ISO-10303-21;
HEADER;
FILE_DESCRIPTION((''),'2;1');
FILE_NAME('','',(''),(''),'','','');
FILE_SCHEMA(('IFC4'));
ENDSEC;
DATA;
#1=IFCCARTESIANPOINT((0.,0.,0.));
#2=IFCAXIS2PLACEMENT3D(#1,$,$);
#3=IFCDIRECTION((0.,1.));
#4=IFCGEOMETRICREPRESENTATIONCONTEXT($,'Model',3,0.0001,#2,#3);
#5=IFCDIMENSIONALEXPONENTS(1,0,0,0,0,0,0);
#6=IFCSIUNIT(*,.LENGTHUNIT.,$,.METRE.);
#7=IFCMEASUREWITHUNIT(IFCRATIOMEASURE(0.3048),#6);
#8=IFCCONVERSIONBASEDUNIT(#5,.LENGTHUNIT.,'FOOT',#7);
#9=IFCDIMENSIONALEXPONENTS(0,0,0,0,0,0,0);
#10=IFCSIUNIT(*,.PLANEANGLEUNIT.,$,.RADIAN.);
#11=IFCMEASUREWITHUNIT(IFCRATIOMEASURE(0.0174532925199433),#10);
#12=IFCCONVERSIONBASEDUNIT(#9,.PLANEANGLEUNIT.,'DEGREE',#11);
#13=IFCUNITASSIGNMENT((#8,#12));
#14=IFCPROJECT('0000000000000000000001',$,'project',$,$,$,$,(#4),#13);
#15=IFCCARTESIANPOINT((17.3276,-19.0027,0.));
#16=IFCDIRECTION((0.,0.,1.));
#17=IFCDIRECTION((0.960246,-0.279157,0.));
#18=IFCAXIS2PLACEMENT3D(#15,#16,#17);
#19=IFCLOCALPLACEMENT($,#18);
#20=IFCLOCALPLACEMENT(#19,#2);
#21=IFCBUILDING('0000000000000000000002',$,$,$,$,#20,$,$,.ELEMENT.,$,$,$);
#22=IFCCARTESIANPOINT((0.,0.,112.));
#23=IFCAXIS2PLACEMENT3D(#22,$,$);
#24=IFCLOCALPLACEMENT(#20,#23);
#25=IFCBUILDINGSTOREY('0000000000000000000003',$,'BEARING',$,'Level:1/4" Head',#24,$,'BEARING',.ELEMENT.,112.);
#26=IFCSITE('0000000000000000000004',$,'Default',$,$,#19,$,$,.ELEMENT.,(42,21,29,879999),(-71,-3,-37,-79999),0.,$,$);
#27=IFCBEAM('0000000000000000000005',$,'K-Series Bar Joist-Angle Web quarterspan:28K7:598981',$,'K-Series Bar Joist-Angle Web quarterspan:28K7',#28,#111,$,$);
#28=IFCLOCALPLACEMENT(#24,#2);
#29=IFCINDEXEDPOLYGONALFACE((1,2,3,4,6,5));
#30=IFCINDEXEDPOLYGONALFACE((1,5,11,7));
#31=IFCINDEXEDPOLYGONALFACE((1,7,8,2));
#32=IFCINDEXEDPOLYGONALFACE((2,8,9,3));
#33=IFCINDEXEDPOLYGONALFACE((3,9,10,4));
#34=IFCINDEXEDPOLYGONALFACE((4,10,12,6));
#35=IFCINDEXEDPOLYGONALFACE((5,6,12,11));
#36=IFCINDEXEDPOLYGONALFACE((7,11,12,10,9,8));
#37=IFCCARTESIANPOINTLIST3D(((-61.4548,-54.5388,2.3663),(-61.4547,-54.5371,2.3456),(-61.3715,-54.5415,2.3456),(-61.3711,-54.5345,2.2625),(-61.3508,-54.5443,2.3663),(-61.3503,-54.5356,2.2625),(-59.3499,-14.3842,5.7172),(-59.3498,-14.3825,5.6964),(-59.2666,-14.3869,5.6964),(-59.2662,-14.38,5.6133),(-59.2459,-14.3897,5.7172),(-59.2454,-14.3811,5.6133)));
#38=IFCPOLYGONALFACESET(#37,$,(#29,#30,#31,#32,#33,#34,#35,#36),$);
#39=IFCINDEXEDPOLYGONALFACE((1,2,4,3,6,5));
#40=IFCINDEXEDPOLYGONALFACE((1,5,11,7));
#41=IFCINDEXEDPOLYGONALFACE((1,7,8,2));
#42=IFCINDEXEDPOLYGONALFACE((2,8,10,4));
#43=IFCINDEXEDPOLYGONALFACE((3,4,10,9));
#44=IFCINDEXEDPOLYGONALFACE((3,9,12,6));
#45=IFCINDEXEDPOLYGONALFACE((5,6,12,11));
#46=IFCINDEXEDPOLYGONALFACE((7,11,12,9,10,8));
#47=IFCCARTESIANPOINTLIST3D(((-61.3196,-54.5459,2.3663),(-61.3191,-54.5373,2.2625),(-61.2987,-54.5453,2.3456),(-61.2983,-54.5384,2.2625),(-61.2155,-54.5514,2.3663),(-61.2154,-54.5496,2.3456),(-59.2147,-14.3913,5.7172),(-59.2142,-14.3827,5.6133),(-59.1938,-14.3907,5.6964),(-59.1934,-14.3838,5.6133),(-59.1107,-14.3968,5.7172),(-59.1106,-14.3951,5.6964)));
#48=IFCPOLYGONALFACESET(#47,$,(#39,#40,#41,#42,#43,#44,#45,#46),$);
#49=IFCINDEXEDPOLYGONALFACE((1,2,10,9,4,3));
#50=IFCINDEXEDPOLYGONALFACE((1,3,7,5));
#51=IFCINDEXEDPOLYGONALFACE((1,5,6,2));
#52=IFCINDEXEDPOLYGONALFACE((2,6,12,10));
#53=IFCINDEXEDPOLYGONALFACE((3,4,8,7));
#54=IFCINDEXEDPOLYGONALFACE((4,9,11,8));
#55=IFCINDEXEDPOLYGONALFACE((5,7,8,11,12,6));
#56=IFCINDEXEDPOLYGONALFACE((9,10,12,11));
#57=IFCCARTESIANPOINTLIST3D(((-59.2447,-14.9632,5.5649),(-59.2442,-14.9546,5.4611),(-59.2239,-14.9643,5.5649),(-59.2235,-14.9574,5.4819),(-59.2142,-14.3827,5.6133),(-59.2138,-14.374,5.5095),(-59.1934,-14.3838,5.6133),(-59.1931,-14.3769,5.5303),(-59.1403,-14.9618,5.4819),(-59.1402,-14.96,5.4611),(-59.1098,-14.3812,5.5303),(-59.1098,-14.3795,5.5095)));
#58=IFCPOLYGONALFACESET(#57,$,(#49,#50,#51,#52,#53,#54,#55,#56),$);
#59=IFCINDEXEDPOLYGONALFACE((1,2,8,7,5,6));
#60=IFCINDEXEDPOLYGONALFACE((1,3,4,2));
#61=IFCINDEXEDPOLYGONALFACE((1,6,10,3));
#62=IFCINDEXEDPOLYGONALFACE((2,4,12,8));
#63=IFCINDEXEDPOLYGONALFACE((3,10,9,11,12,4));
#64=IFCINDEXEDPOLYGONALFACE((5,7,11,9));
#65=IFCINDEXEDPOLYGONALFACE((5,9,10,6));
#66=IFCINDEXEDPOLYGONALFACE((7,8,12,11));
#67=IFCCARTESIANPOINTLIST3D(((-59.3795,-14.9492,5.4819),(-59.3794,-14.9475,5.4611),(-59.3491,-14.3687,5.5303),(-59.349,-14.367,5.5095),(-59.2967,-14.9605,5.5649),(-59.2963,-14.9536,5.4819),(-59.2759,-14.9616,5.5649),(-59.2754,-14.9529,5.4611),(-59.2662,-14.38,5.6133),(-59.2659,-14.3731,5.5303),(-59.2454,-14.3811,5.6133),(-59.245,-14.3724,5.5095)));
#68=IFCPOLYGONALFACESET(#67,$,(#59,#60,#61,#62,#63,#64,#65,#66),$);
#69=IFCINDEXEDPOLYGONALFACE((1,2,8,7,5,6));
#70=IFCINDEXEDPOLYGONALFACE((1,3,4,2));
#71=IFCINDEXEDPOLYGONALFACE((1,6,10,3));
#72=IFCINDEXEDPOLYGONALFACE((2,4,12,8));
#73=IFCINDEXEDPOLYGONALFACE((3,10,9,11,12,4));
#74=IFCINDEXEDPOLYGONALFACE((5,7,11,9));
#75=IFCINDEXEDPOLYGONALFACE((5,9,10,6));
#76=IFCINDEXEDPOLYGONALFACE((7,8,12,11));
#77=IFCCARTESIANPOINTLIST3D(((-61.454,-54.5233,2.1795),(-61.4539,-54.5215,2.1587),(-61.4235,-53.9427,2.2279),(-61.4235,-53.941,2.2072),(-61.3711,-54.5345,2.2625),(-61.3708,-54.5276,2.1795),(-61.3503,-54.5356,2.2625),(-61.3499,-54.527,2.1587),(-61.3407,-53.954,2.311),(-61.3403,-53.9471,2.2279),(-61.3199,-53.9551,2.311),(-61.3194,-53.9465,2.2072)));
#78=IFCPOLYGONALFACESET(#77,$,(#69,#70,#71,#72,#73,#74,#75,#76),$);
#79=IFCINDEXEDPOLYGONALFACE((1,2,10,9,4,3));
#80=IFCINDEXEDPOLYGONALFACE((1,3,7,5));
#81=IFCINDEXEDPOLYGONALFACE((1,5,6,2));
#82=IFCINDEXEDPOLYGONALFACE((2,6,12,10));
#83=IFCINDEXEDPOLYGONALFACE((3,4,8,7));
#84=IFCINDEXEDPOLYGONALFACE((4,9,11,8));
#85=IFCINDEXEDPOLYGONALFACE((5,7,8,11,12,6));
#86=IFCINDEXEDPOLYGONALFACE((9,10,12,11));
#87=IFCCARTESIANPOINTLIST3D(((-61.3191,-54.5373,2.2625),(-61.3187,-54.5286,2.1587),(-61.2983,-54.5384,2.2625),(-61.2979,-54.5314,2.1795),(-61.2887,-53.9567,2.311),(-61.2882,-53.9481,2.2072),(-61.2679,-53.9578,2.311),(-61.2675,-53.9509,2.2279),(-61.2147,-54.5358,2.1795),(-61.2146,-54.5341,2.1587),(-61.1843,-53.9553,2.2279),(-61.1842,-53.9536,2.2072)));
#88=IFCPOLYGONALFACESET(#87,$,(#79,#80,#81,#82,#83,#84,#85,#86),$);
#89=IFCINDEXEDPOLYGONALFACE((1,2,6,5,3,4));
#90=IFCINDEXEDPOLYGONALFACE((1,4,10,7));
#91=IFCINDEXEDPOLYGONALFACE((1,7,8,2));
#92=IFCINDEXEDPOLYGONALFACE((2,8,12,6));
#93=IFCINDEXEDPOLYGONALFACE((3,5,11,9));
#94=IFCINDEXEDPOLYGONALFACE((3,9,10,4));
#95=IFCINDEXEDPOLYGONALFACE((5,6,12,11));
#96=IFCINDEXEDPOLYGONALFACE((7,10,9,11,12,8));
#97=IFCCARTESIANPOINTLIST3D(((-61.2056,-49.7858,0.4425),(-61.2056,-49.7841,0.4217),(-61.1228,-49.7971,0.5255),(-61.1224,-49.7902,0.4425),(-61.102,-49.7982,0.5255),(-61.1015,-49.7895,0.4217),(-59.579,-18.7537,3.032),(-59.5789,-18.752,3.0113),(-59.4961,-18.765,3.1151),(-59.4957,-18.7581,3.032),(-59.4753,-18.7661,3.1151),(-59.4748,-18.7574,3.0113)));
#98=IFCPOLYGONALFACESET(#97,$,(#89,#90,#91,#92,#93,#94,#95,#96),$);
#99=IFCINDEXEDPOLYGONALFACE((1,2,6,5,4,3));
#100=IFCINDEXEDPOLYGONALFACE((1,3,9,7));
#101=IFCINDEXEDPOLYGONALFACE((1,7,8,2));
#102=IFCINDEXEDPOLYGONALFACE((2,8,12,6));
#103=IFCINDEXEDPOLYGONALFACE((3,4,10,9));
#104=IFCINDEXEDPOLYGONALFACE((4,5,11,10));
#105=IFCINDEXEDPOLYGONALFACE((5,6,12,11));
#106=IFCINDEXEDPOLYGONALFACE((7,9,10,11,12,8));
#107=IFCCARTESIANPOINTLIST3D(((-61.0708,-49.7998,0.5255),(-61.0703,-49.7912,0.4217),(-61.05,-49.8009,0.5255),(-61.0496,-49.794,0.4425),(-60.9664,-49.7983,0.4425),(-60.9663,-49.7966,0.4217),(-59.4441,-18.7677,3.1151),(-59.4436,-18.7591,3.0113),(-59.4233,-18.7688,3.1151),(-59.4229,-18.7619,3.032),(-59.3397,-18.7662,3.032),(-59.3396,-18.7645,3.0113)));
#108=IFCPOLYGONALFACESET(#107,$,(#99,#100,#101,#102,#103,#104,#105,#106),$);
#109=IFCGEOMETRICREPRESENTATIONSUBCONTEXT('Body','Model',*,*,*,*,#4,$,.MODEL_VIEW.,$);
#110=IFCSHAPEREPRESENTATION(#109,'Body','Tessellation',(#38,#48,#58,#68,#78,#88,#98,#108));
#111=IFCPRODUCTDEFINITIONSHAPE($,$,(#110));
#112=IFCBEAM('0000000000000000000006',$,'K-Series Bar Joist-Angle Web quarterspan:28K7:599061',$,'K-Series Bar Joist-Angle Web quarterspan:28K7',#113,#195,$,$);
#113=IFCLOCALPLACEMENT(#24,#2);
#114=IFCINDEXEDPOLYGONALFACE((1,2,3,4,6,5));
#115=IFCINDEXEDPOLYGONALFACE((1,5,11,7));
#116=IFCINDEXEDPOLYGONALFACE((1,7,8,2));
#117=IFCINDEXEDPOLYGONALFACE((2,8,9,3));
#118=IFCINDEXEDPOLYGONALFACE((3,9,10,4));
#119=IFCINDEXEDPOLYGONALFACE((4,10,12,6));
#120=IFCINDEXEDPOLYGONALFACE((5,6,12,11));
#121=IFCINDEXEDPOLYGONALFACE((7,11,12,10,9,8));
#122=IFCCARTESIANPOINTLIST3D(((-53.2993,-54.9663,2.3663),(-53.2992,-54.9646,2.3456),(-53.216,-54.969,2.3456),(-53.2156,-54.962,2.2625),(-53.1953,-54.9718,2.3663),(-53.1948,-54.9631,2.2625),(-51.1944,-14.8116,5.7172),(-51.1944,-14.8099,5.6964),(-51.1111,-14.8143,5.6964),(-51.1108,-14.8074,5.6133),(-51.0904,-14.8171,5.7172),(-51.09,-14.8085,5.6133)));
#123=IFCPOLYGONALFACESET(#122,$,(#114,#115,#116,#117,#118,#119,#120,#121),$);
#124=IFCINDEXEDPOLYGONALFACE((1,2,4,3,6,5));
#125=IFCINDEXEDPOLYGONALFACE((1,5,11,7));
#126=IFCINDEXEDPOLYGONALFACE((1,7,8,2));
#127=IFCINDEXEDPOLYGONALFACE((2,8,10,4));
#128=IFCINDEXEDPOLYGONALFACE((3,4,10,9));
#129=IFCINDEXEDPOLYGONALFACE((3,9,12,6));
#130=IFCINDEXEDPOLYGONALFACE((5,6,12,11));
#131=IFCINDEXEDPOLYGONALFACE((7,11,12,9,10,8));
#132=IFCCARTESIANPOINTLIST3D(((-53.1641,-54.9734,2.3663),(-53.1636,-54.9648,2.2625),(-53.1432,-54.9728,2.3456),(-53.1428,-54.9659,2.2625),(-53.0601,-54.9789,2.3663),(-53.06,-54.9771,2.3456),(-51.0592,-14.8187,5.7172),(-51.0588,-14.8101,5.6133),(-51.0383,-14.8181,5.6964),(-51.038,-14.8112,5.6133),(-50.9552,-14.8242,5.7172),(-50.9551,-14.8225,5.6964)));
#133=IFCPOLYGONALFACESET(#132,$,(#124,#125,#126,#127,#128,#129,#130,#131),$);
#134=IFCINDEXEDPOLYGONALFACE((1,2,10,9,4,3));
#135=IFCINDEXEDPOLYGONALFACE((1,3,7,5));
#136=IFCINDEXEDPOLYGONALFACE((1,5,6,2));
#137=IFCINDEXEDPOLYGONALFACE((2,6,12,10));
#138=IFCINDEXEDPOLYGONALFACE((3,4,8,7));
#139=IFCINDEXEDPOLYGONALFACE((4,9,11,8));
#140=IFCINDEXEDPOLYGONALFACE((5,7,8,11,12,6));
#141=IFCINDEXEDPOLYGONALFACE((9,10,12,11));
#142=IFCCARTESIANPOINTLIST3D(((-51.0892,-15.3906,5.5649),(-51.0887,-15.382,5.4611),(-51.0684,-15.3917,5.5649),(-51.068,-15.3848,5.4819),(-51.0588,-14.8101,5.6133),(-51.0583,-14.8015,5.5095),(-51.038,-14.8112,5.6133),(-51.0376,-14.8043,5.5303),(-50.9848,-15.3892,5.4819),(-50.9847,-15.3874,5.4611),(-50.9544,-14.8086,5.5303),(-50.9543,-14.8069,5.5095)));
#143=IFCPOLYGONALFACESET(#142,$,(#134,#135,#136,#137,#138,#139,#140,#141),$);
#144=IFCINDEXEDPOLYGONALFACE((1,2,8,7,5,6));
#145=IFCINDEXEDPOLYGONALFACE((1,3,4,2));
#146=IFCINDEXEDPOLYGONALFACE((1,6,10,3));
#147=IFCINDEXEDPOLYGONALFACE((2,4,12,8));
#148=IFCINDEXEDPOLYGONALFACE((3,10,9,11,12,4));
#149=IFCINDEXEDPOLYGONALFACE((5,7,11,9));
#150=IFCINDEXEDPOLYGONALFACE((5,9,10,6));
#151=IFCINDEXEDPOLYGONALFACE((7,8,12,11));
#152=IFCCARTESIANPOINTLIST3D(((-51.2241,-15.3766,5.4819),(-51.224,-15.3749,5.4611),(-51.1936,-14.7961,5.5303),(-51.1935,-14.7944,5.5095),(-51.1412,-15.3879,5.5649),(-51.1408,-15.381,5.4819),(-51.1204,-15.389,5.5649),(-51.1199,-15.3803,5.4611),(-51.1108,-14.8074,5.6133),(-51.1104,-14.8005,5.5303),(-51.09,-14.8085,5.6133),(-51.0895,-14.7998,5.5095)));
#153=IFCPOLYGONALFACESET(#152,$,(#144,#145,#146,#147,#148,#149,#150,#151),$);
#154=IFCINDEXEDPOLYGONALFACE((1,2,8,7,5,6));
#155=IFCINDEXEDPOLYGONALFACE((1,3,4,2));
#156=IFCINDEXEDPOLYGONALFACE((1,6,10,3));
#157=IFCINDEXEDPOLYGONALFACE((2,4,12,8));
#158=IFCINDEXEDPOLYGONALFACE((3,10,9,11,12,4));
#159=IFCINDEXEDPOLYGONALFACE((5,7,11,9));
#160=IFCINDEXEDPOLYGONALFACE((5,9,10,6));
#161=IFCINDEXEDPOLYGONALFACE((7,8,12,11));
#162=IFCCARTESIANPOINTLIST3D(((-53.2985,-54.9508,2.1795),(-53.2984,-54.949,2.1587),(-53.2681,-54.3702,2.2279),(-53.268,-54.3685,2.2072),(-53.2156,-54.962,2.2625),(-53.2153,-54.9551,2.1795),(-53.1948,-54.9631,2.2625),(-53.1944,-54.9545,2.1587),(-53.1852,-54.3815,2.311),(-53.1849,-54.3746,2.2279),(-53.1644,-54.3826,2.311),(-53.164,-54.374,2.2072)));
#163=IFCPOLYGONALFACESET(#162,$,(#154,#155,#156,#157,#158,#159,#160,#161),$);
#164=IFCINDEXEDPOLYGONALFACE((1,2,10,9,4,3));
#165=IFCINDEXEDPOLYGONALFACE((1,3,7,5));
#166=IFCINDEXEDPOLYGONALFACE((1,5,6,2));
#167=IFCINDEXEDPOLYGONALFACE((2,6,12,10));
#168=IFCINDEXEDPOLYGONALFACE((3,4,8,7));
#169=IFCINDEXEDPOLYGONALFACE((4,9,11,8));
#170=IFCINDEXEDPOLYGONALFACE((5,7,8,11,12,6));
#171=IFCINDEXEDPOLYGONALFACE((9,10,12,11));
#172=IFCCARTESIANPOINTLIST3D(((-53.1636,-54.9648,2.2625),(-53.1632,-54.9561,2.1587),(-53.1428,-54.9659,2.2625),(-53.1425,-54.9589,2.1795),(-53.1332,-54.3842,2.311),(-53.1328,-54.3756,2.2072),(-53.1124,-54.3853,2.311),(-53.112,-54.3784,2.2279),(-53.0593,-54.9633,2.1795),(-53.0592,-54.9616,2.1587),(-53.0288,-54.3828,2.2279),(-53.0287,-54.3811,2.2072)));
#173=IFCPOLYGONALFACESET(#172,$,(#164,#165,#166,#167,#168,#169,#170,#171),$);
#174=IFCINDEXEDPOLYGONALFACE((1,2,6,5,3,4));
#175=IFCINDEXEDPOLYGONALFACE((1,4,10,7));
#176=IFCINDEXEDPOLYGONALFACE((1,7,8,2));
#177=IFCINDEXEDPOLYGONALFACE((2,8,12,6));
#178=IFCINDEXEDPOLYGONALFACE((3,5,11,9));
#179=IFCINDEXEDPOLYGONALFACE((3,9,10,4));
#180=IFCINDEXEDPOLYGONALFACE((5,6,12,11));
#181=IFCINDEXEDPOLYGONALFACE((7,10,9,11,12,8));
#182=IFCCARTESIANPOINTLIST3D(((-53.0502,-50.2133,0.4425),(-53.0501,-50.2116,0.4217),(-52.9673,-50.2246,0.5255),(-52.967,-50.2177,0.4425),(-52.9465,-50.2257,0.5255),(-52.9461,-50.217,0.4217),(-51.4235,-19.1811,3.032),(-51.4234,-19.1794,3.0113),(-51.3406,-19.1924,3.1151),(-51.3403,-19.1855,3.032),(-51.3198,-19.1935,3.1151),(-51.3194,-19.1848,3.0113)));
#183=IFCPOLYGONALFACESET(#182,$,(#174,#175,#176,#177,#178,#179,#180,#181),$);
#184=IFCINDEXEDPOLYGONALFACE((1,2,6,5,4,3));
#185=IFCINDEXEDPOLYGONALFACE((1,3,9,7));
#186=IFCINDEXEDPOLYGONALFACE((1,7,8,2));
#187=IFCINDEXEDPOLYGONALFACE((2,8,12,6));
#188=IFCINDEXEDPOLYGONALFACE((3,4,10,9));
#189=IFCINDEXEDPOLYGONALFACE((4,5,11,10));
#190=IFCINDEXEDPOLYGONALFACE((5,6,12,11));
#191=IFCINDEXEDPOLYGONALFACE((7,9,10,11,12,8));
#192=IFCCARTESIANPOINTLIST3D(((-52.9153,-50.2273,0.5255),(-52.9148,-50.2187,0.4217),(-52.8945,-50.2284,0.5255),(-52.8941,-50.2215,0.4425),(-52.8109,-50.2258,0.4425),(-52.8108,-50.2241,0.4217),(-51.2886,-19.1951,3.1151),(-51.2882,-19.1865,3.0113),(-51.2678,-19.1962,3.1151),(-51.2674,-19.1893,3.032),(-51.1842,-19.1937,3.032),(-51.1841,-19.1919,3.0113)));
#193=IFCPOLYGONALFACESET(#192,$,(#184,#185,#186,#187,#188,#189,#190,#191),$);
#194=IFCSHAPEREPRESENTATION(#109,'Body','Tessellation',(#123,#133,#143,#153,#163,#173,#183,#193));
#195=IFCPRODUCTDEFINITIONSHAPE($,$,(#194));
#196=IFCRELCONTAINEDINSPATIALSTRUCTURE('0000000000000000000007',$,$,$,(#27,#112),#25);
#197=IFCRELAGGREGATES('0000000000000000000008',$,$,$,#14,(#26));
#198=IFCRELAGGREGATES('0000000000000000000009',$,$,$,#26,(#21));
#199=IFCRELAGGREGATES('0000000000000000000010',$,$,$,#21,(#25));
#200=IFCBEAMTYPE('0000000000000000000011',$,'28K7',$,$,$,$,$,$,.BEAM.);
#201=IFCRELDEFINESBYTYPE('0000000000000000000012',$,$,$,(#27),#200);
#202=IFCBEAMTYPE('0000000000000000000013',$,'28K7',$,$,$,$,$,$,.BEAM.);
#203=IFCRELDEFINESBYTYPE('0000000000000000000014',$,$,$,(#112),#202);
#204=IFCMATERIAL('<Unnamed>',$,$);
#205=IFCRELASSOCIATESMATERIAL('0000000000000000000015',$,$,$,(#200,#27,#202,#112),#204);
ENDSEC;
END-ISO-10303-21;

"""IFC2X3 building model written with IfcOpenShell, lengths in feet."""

from ifc_helpers import new_model, entity, si_unit, converted_unit, direction, frame, origin, place, context, subcontext, project, spatial, polyline, outline, extrude, source, transform, mapped, material, type_object, type_shapes, element, save


model = new_model("IFC2X3")

# Units and contexts
model_context = context("Model", 3, precision=0.0001, world=origin(), true_north=direction((0.0, 1.0)))
body_context = subcontext(model_context, "Body", "Model", "MODEL_VIEW")
ifc_project = project(units=[converted_unit("LENGTHUNIT", "FOOT", entity("IfcRatioMeasure", 0.3048), si_unit("LENGTHUNIT", "METRE"), dimensions=[1, 0, 0, 0, 0, 0, 0]), converted_unit("PLANEANGLEUNIT", "DEGREE", entity("IfcRatioMeasure", 0.0174532925199433), si_unit("PLANEANGLEUNIT", "RADIAN"), dimensions=[0, 0, 0, 0, 0, 0, 0])], contexts=[model_context])

# Site, building, storey
site_placement = place(None, frame((17.3276, -19.0027, 0.0), z_axis=(0.0, 0.0, 1.0), x_axis=(0.960246, -0.279157, 0.0)))
site = spatial("IfcSite", under=ifc_project, at=site_placement, Name="Default", CompositionType="ELEMENT", RefLatitude=(42, 21, 29, 879999), RefLongitude=(-71, -3, -37, -79999), RefElevation=0.0)
building_placement = place(site_placement, origin())
building = spatial("IfcBuilding", under=site, at=building_placement, CompositionType="ELEMENT")
storey_placement = place(building_placement, frame((0.0, 0.0, 112.0)))
storey = spatial("IfcBuildingStorey", under=building, at=storey_placement, Name="BEARING", ObjectType="Level:1/4\" Head", LongName="BEARING", CompositionType="ELEMENT", Elevation=112.0)

# Shared definitions
ifc_material_1 = material(Name="<Unnamed>")

# Beams
beam_type_1 = type_object("IfcBeamType", Name="28K7", PredefinedType="BEAM", material=ifc_material_1)
shared_shape_1 = source(origin(), body_context, "Body", "SweptSolid", [
    extrude(outline(polyline([(-0.0417, -0.0625), (-0.0208, -0.0625), (-0.0208, 0.0208), (0.0625, 0.0208), (0.0625, 0.0417), (-0.0417, 0.0417), (-0.0417, -0.0625)])), frame((-20.1745, -0.0573, 1.125), z_axis=(1.0, 0.0, 0.0), x_axis=(0.0, 0.0, -1.0)), (0.0, 0.0, 1.0), 40.3491),
    extrude(outline(polyline([(-0.0417, -0.0417), (0.0625, -0.0417), (0.0625, -0.0208), (-0.0208, -0.0208), (-0.0208, 0.0625), (-0.0417, 0.0625), (-0.0417, -0.0417)])), frame((-20.1745, 0.0573, 1.125), z_axis=(1.0, 0.0, 0.0), x_axis=(0.0, 0.0, -1.0)), (0.0, 0.0, 1.0), 40.3491),
    extrude(outline(polyline([(-0.0625, -0.0417), (0.0417, -0.0417), (0.0417, 0.0625), (0.0208, 0.0625), (0.0208, -0.0208), (-0.0625, -0.0208), (-0.0625, -0.0417)])), frame((-20.1745, 0.0573, 1.0), z_axis=(1.0, 0.0, 0.0), x_axis=(0.0, 0.0, -1.0)), (0.0, 0.0, 1.0), 0.5833),
    extrude(outline(polyline([(0.0208, -0.0625), (0.0417, -0.0625), (0.0417, 0.0417), (-0.0625, 0.0417), (-0.0625, 0.0208), (0.0208, 0.0208), (0.0208, -0.0625)])), frame((-20.1745, -0.0573, 1.0), z_axis=(1.0, 0.0, 0.0), x_axis=(0.0, 0.0, -1.0)), (0.0, 0.0, 1.0), 0.5833),
    extrude(outline(polyline([(0.0208, -0.0625), (0.0417, -0.0625), (0.0417, 0.0417), (-0.0625, 0.0417), (-0.0625, 0.0208), (0.0208, 0.0208), (0.0208, -0.0625)])), frame((19.5912, -0.0573, 1.0), z_axis=(1.0, 0.0, 0.0), x_axis=(0.0, 0.0, -1.0)), (0.0, 0.0, 1.0), 0.5833),
    extrude(outline(polyline([(-0.0625, -0.0417), (0.0417, -0.0417), (0.0417, 0.0625), (0.0208, 0.0625), (0.0208, -0.0208), (-0.0625, -0.0208), (-0.0625, -0.0417)])), frame((19.5912, 0.0573, 1.0), z_axis=(1.0, 0.0, 0.0), x_axis=(0.0, 0.0, -1.0)), (0.0, 0.0, 1.0), 0.5833),
    extrude(outline(polyline([(0.0208, -0.0625), (0.0417, -0.0625), (0.0417, 0.0417), (-0.0625, 0.0417), (-0.0625, 0.0208), (0.0208, 0.0208), (0.0208, -0.0625)])), frame((-15.5912, -0.0573, -1.125), z_axis=(1.0, 0.0, 0.0), x_axis=(0.0, 0.0, -1.0)), (0.0, 0.0, 1.0), 31.1824),
    extrude(outline(polyline([(-0.0625, -0.0417), (0.0417, -0.0417), (0.0417, 0.0625), (0.0208, 0.0625), (0.0208, -0.0208), (-0.0625, -0.0208), (-0.0625, -0.0417)])), frame((-15.5912, 0.0573, -1.125), z_axis=(1.0, 0.0, 0.0), x_axis=(0.0, 0.0, -1.0)), (0.0, 0.0, 1.0), 31.1824),
])
type_shapes(beam_type_1, [shared_shape_1])
beam_1_placement = place(storey_placement, frame((-60.2777, -34.371, 2.8791), z_axis=(-0.004347, -0.082932, 0.996546), x_axis=(-0.052167, -0.995179, -0.083046)))
element("IfcBeam", 1, at=beam_1_placement, inside=storey, type_object=beam_type_1, material=ifc_material_1, Name="K-Series Bar Joist-Angle Web quarterspan:28K7:598981", ObjectType="K-Series Bar Joist-Angle Web quarterspan:28K7", context=body_context, shape_type="MappedRepresentation", body=[
    mapped(shared_shape_1, transform((0.0, 0.0, 0.0), scale=1.0)),
])
beam_type_2 = type_object("IfcBeamType", Name="28K7", PredefinedType="BEAM", material=ifc_material_1)
shared_shape_2 = source(origin(), body_context, "Body", "SweptSolid", [
    extrude(outline(polyline([(-0.0417, -0.0625), (-0.0208, -0.0625), (-0.0208, 0.0208), (0.0625, 0.0208), (0.0625, 0.0417), (-0.0417, 0.0417), (-0.0417, -0.0625)])), frame((-20.1746, -0.0573, 1.125), z_axis=(1.0, 0.0, 0.0), x_axis=(0.0, 0.0, -1.0)), (0.0, 0.0, 1.0), 40.3492),
    extrude(outline(polyline([(-0.0417, -0.0417), (0.0625, -0.0417), (0.0625, -0.0208), (-0.0208, -0.0208), (-0.0208, 0.0625), (-0.0417, 0.0625), (-0.0417, -0.0417)])), frame((-20.1746, 0.0573, 1.125), z_axis=(1.0, 0.0, 0.0), x_axis=(0.0, 0.0, -1.0)), (0.0, 0.0, 1.0), 40.3492),
    extrude(outline(polyline([(-0.0625, -0.0417), (0.0417, -0.0417), (0.0417, 0.0625), (0.0208, 0.0625), (0.0208, -0.0208), (-0.0625, -0.0208), (-0.0625, -0.0417)])), frame((-20.1746, 0.0573, 1.0), z_axis=(1.0, 0.0, 0.0), x_axis=(0.0, 0.0, -1.0)), (0.0, 0.0, 1.0), 0.5833),
    extrude(outline(polyline([(0.0208, -0.0625), (0.0417, -0.0625), (0.0417, 0.0417), (-0.0625, 0.0417), (-0.0625, 0.0208), (0.0208, 0.0208), (0.0208, -0.0625)])), frame((-20.1746, -0.0573, 1.0), z_axis=(1.0, 0.0, 0.0), x_axis=(0.0, 0.0, -1.0)), (0.0, 0.0, 1.0), 0.5833),
    extrude(outline(polyline([(0.0208, -0.0625), (0.0417, -0.0625), (0.0417, 0.0417), (-0.0625, 0.0417), (-0.0625, 0.0208), (0.0208, 0.0208), (0.0208, -0.0625)])), frame((19.5913, -0.0573, 1.0), z_axis=(1.0, 0.0, 0.0), x_axis=(0.0, 0.0, -1.0)), (0.0, 0.0, 1.0), 0.5833),
    extrude(outline(polyline([(-0.0625, -0.0417), (0.0417, -0.0417), (0.0417, 0.0625), (0.0208, 0.0625), (0.0208, -0.0208), (-0.0625, -0.0208), (-0.0625, -0.0417)])), frame((19.5913, 0.0573, 1.0), z_axis=(1.0, 0.0, 0.0), x_axis=(0.0, 0.0, -1.0)), (0.0, 0.0, 1.0), 0.5833),
    extrude(outline(polyline([(0.0208, -0.0625), (0.0417, -0.0625), (0.0417, 0.0417), (-0.0625, 0.0417), (-0.0625, 0.0208), (0.0208, 0.0208), (0.0208, -0.0625)])), frame((-15.5913, -0.0573, -1.125), z_axis=(1.0, 0.0, 0.0), x_axis=(0.0, 0.0, -1.0)), (0.0, 0.0, 1.0), 31.1825),
    extrude(outline(polyline([(-0.0625, -0.0417), (0.0417, -0.0417), (0.0417, 0.0625), (0.0208, 0.0625), (0.0208, -0.0208), (-0.0625, -0.0208), (-0.0625, -0.0417)])), frame((-15.5913, 0.0573, -1.125), z_axis=(1.0, 0.0, 0.0), x_axis=(0.0, 0.0, -1.0)), (0.0, 0.0, 1.0), 31.1825),
])
type_shapes(beam_type_2, [shared_shape_2])
beam_2_placement = place(storey_placement, frame((-52.1222, -34.7985, 2.8791), z_axis=(-0.004347, -0.082931, 0.996546), x_axis=(-0.052167, -0.995179, -0.083045)))
element("IfcBeam", 2, at=beam_2_placement, inside=storey, type_object=beam_type_2, material=ifc_material_1, Name="K-Series Bar Joist-Angle Web quarterspan:28K7:599061", ObjectType="K-Series Bar Joist-Angle Web quarterspan:28K7", context=body_context, shape_type="MappedRepresentation", body=[
    mapped(shared_shape_2, transform((0.0, 0.0, 0.0), scale=1.0)),
])

save(model, "model.ifc")
